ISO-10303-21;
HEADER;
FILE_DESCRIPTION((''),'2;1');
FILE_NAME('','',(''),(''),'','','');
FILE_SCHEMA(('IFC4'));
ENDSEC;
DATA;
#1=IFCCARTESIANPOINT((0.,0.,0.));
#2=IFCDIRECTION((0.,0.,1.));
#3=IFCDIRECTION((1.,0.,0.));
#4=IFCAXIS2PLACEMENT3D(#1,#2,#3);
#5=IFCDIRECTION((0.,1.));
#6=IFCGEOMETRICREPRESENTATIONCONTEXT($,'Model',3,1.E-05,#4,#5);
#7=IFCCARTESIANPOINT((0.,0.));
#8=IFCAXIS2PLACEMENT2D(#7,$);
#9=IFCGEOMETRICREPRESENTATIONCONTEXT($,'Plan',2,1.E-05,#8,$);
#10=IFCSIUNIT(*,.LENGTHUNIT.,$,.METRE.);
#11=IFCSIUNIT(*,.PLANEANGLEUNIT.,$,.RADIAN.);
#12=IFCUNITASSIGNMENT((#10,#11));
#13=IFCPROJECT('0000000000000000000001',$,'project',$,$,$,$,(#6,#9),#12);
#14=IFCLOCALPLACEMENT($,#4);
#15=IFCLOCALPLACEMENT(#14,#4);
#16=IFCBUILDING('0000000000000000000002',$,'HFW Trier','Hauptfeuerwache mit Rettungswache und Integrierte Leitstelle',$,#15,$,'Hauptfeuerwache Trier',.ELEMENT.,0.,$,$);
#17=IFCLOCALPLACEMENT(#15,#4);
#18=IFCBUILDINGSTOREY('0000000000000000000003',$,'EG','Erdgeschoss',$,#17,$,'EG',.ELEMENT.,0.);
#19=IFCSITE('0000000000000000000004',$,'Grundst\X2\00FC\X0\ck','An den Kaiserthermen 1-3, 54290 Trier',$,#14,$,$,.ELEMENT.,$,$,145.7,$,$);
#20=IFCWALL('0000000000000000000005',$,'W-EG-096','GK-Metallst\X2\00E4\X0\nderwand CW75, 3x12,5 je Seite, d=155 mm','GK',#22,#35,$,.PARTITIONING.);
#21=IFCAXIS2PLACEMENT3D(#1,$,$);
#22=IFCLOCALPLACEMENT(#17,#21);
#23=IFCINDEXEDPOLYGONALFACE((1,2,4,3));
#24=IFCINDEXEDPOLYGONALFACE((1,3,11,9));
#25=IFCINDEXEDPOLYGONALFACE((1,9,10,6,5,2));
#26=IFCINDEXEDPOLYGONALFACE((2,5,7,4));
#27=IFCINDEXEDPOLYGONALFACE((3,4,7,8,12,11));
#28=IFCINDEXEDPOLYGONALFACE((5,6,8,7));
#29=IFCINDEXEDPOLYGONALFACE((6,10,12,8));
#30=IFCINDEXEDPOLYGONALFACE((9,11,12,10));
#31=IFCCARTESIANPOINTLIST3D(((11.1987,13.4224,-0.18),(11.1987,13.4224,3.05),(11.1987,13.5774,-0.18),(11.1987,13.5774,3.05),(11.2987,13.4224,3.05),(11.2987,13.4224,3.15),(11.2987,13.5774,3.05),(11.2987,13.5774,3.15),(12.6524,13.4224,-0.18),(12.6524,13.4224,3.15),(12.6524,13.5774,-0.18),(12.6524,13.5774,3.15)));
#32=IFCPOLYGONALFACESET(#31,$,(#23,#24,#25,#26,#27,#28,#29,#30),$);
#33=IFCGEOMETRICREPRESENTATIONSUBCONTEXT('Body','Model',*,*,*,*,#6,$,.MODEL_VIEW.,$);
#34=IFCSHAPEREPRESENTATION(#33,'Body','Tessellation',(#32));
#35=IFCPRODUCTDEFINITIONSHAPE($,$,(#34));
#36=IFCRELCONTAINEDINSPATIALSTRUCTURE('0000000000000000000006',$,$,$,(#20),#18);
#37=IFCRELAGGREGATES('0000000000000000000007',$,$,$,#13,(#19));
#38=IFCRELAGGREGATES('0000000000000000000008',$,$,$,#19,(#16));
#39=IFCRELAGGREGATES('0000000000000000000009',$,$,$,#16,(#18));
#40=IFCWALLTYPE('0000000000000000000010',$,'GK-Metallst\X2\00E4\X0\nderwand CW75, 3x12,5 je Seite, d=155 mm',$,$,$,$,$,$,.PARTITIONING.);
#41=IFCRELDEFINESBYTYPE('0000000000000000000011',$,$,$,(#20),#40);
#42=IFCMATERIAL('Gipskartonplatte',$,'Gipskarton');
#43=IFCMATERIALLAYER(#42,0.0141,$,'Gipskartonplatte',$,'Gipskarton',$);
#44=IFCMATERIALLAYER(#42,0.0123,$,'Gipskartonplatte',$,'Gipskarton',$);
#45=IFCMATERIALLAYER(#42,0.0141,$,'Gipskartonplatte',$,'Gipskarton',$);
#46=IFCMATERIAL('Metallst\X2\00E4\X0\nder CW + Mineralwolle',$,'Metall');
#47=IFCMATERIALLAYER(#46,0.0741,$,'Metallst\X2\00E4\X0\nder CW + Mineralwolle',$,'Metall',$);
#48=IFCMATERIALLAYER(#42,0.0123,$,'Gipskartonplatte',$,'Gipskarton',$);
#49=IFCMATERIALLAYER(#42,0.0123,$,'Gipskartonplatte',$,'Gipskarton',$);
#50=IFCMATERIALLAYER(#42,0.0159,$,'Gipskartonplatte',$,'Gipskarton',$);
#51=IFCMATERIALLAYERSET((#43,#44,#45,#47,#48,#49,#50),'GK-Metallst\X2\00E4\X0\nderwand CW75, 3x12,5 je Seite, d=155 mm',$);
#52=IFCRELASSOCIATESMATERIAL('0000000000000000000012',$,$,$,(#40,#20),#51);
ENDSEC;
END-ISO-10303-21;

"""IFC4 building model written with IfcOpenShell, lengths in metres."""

from ifc_helpers import new_model, si_unit, direction, frame, frame_2d, origin_with_axes, origin_2d, place, context, subcontext, project, spatial, rectangle, extrude, material, layer, layer_set, layer_usage, type_object, element, save


model = new_model("IFC4")

# Units and contexts
model_context = context("Model", 3, precision=1e-05, world=origin_with_axes(), true_north=direction((0.0, 1.0)))
plan_context = context("Plan", 2, precision=1e-05, world=origin_2d())
body_context = subcontext(model_context, "Body", "Model", "MODEL_VIEW")
ifc_project = project(units=[si_unit("LENGTHUNIT", "METRE"), si_unit("PLANEANGLEUNIT", "RADIAN")], contexts=[model_context, plan_context])

# Site, building, storey
site_placement = place(None, origin_with_axes())
site = spatial("IfcSite", under=ifc_project, at=site_placement, Name="Grundstück", Description="An den Kaiserthermen 1-3, 54290 Trier", CompositionType="ELEMENT", RefElevation=145.7)
building_placement = place(site_placement, origin_with_axes())
building = spatial("IfcBuilding", under=site, at=building_placement, Name="HFW Trier", Description="Hauptfeuerwache mit Rettungswache und Integrierte Leitstelle", LongName="Hauptfeuerwache Trier", CompositionType="ELEMENT", ElevationOfRefHeight=0.0)
storey_placement = place(building_placement, origin_with_axes())
storey = spatial("IfcBuildingStorey", under=building, at=storey_placement, Name="EG", Description="Erdgeschoss", LongName="EG", CompositionType="ELEMENT", Elevation=0.0)

# Shared definitions
ifc_material_1 = material(Name="Metallständer CW + Mineralwolle", Category="Metall")

# Shared definitions
ifc_material_2 = material(Name="Gipskartonplatte", Category="Gipskarton")

# Wall, opening
ifc_layer_1 = layer(ifc_material_2, 0.0141, Name="Gipskartonplatte", Category="Gipskarton")
ifc_layer_2 = layer(ifc_material_2, 0.0123, Name="Gipskartonplatte", Category="Gipskarton")
ifc_layer_3 = layer(ifc_material_2, 0.0141, Name="Gipskartonplatte", Category="Gipskarton")
ifc_layer_4 = layer(ifc_material_1, 0.0741, Name="Metallständer CW + Mineralwolle", Category="Metall")
ifc_layer_5 = layer(ifc_material_2, 0.0123, Name="Gipskartonplatte", Category="Gipskarton")
ifc_layer_6 = layer(ifc_material_2, 0.0123, Name="Gipskartonplatte", Category="Gipskarton")
ifc_layer_7 = layer(ifc_material_2, 0.0159, Name="Gipskartonplatte", Category="Gipskarton")
ifc_layer_set_1 = layer_set([ifc_layer_1, ifc_layer_2, ifc_layer_3, ifc_layer_4, ifc_layer_5, ifc_layer_6, ifc_layer_7], Name="GK-Metallständerwand CW75, 3x12,5 je Seite, d=155 mm")
ifc_layer_usage_1 = layer_usage(ifc_layer_set_1, "AXIS2", "POSITIVE", -0.0775)
wall_type_1 = type_object("IfcWallType", Name="GK-Metallständerwand CW75, 3x12,5 je Seite, d=155 mm", PredefinedType="PARTITIONING", material=ifc_layer_set_1)
wall_1_placement = place(storey_placement, frame((11.1987, 13.4999, -0.18), z_axis=(0.0, 0.0, 1.0), x_axis=(1.0, 0.0, 0.0)))
wall_1 = element("IfcWall", 1, at=wall_1_placement, inside=storey, type_object=wall_type_1, material=ifc_layer_usage_1, Name="W-EG-096", Description="GK-Metallständerwand CW75, 3x12,5 je Seite, d=155 mm", ObjectType="GK", PredefinedType="PARTITIONING", context=body_context, shape_type="SweptSolid", body=[
    extrude(rectangle(XDim=1.4537, YDim=0.155, at=frame_2d((0.7268, 0.0))), origin_with_axes(), (0.0, 0.0, 1.0), 3.33),
])
opening_1_placement = place(wall_1_placement, origin_with_axes())
element("IfcOpeningElement", 2, at=opening_1_placement, cuts=wall_1, ObjectType="Wanddurchbruch", PredefinedType="OPENING", context=body_context, shape_type="SweptSolid", body=[
    extrude(rectangle(XDim=0.1, YDim=0.255, at=frame_2d((0.05, 0.0))), frame((0.0, 0.0, 3.23), z_axis=(0.0, 0.0, 1.0), x_axis=(1.0, 0.0, 0.0)), (0.0, 0.0, 1.0), 0.1),
])

save(model, "model.ifc")
